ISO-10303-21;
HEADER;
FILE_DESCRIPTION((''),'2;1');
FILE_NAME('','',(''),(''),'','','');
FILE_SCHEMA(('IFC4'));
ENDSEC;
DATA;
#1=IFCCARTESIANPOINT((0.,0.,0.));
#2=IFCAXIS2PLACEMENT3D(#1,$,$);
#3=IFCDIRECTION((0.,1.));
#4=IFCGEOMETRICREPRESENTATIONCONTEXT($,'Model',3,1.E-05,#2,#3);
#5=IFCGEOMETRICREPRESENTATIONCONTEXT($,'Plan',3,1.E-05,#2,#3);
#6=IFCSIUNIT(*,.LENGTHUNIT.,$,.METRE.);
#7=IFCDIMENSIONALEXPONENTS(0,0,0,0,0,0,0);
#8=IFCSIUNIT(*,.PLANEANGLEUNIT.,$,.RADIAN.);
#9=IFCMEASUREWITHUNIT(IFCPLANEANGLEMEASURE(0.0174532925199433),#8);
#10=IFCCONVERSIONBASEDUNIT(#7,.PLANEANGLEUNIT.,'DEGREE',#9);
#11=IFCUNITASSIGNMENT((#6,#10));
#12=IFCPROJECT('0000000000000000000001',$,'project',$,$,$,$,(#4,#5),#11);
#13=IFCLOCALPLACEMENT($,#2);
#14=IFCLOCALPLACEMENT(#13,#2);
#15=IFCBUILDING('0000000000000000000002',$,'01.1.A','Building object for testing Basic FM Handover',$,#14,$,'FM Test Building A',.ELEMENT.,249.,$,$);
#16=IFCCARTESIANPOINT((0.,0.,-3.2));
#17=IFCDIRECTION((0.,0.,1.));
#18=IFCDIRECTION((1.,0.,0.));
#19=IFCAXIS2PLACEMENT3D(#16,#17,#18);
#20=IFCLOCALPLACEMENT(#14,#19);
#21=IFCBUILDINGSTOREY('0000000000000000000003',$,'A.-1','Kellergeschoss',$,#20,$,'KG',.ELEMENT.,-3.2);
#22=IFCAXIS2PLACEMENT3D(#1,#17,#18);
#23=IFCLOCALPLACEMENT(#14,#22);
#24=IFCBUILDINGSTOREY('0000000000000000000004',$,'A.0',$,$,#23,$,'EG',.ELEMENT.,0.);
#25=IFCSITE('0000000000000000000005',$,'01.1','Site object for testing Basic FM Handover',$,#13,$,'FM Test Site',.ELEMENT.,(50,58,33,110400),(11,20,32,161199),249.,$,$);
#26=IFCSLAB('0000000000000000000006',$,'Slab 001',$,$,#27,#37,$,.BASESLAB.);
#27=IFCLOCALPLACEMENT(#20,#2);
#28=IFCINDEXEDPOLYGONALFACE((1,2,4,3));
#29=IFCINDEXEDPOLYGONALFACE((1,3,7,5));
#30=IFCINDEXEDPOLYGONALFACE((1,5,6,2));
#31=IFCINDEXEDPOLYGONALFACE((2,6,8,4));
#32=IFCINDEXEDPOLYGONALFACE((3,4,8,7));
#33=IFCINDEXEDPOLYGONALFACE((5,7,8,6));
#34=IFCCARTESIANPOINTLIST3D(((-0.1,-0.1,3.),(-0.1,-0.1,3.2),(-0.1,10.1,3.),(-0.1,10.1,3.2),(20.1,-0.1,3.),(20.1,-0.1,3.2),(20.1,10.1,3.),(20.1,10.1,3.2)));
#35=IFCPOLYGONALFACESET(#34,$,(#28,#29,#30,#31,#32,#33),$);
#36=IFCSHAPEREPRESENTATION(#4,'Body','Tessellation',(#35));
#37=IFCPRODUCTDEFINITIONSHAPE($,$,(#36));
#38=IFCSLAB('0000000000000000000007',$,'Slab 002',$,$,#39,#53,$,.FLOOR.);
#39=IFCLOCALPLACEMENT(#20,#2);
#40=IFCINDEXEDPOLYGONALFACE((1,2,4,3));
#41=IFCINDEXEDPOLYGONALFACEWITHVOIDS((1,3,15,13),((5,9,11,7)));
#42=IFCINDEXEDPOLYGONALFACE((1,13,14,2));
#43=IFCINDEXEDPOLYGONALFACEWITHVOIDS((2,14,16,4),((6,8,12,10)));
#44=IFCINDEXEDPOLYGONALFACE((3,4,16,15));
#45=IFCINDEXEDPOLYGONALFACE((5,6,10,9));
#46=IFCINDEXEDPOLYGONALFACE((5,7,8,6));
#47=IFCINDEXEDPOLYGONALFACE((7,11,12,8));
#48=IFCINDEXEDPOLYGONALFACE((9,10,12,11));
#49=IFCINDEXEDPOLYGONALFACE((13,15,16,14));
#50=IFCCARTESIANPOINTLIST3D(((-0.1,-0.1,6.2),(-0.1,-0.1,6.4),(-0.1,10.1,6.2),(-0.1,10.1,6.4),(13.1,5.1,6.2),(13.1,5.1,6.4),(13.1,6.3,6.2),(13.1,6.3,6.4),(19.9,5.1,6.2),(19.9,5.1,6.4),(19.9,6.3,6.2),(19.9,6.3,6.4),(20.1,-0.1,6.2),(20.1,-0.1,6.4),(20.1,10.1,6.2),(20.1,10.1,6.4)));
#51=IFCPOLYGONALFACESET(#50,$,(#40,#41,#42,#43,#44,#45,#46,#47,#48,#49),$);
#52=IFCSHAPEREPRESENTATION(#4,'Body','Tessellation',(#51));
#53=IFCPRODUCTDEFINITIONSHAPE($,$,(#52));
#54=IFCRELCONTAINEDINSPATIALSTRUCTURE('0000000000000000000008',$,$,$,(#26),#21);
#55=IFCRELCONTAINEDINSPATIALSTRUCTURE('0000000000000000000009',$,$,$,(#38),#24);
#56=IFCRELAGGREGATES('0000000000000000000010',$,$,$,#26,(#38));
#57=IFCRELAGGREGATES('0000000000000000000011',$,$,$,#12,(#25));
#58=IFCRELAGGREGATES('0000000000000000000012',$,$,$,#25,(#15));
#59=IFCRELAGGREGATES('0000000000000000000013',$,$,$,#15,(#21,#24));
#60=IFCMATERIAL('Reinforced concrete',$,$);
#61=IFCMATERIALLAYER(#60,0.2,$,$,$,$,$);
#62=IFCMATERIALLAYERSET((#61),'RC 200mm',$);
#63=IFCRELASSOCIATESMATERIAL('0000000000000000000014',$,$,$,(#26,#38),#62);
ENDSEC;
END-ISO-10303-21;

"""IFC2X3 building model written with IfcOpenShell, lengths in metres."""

from ifc_helpers import new_model, entity, si_unit, converted_unit, direction, frame, origin, origin_with_axes, place, context, project, spatial, polyline, outline, extrude, material, layer, layer_set, layer_usage, element, aggregate, save


model = new_model("IFC2X3")

# Units and contexts
model_context = context("Model", 3, precision=1e-05, world=origin(), true_north=direction((0.0, 1.0)))
plan_context = context("Plan", 3, precision=1e-05, world=origin(), true_north=direction((0.0, 1.0)))
ifc_project = project(units=[si_unit("LENGTHUNIT", "METRE"), converted_unit("PLANEANGLEUNIT", "DEGREE", entity("IfcPlaneAngleMeasure", 0.0174532925199433), si_unit("PLANEANGLEUNIT", "RADIAN"), dimensions=[0, 0, 0, 0, 0, 0, 0])], contexts=[model_context, plan_context])

# Site, building, storey
site_placement = place(None, origin())
site = spatial("IfcSite", under=ifc_project, at=site_placement, Name="01.1", Description="Site object for testing Basic FM Handover", LongName="FM Test Site", CompositionType="ELEMENT", RefLatitude=(50, 58, 33, 110400), RefLongitude=(11, 20, 32, 161199), RefElevation=249.0)
building_placement = place(site_placement, origin())
building = spatial("IfcBuilding", under=site, at=building_placement, Name="01.1.A", Description="Building object for testing Basic FM Handover", LongName="FM Test Building A", CompositionType="ELEMENT", ElevationOfRefHeight=249.0)
storey_1_placement = place(building_placement, frame((0.0, 0.0, -3.2), z_axis=(0.0, 0.0, 1.0), x_axis=(1.0, 0.0, 0.0)))
storey_1 = spatial("IfcBuildingStorey", under=building, at=storey_1_placement, Name="A.-1", Description="Kellergeschoss", LongName="KG", CompositionType="ELEMENT", Elevation=-3.2)

# Slab
ifc_material = material(Name="Reinforced concrete")
ifc_layer = layer(ifc_material, 0.2)
ifc_layer_set = layer_set([ifc_layer], Name="RC 200mm")
ifc_layer_usage_1 = layer_usage(ifc_layer_set, "AXIS3", "POSITIVE", 0.0)
slab_1_placement = place(storey_1_placement, frame((0.0, 0.0, 3.0), z_axis=(0.0, 0.0, 1.0), x_axis=(1.0, 0.0, 0.0)))
slab_1 = element("IfcSlab", 1, at=slab_1_placement, inside=storey_1, material=ifc_layer_usage_1, Name="Slab 001", PredefinedType="BASESLAB", context=model_context, shape_type="SweptSolid", body=[
    extrude(outline(polyline([(-0.1, -0.1), (20.1, -0.1), (20.1, 10.1), (-0.1, 10.1), (-0.1, -0.1)])), origin(), (0.0, 0.0, 1.0), 0.2),
])

# Shared definitions
storey_2_placement = place(building_placement, origin_with_axes())
storey_2 = spatial("IfcBuildingStorey", under=building, at=storey_2_placement, Name="A.0", LongName="EG", CompositionType="ELEMENT", Elevation=0.0)

# Slab, opening
ifc_layer_usage_2 = layer_usage(ifc_layer_set, "AXIS3", "POSITIVE", 0.0)
slab_2_placement = place(storey_2_placement, frame((0.0, 0.0, 3.0), z_axis=(0.0, 0.0, 1.0), x_axis=(1.0, 0.0, 0.0)))
slab_2 = element("IfcSlab", 2, at=slab_2_placement, inside=storey_2, material=ifc_layer_usage_2, Name="Slab 002", PredefinedType="FLOOR", context=model_context, shape_type="SweptSolid", body=[
    extrude(outline(polyline([(-0.1, -0.1), (20.1, -0.1), (20.1, 10.1), (-0.1, 10.1), (-0.1, -0.1)])), origin(), (0.0, 0.0, 1.0), 0.2),
])
opening_placement = place(slab_2_placement, frame((13.1, 5.1, 0.0), z_axis=(0.0, 0.0, 1.0), x_axis=(1.0, 0.0, 0.0)))
element("IfcOpeningElement", 3, at=opening_placement, cuts=slab_2, context=model_context, shape_type="SweptSolid", body=[
    extrude(outline(polyline([(0.0, 0.0), (6.8, 0.0), (6.8, 1.2), (0.0, 1.2), (0.0, 0.0)])), origin(), (0.0, 0.0, 1.0), 0.2),
])
aggregate(slab_1, [slab_2])

save(model, "model.ifc")
